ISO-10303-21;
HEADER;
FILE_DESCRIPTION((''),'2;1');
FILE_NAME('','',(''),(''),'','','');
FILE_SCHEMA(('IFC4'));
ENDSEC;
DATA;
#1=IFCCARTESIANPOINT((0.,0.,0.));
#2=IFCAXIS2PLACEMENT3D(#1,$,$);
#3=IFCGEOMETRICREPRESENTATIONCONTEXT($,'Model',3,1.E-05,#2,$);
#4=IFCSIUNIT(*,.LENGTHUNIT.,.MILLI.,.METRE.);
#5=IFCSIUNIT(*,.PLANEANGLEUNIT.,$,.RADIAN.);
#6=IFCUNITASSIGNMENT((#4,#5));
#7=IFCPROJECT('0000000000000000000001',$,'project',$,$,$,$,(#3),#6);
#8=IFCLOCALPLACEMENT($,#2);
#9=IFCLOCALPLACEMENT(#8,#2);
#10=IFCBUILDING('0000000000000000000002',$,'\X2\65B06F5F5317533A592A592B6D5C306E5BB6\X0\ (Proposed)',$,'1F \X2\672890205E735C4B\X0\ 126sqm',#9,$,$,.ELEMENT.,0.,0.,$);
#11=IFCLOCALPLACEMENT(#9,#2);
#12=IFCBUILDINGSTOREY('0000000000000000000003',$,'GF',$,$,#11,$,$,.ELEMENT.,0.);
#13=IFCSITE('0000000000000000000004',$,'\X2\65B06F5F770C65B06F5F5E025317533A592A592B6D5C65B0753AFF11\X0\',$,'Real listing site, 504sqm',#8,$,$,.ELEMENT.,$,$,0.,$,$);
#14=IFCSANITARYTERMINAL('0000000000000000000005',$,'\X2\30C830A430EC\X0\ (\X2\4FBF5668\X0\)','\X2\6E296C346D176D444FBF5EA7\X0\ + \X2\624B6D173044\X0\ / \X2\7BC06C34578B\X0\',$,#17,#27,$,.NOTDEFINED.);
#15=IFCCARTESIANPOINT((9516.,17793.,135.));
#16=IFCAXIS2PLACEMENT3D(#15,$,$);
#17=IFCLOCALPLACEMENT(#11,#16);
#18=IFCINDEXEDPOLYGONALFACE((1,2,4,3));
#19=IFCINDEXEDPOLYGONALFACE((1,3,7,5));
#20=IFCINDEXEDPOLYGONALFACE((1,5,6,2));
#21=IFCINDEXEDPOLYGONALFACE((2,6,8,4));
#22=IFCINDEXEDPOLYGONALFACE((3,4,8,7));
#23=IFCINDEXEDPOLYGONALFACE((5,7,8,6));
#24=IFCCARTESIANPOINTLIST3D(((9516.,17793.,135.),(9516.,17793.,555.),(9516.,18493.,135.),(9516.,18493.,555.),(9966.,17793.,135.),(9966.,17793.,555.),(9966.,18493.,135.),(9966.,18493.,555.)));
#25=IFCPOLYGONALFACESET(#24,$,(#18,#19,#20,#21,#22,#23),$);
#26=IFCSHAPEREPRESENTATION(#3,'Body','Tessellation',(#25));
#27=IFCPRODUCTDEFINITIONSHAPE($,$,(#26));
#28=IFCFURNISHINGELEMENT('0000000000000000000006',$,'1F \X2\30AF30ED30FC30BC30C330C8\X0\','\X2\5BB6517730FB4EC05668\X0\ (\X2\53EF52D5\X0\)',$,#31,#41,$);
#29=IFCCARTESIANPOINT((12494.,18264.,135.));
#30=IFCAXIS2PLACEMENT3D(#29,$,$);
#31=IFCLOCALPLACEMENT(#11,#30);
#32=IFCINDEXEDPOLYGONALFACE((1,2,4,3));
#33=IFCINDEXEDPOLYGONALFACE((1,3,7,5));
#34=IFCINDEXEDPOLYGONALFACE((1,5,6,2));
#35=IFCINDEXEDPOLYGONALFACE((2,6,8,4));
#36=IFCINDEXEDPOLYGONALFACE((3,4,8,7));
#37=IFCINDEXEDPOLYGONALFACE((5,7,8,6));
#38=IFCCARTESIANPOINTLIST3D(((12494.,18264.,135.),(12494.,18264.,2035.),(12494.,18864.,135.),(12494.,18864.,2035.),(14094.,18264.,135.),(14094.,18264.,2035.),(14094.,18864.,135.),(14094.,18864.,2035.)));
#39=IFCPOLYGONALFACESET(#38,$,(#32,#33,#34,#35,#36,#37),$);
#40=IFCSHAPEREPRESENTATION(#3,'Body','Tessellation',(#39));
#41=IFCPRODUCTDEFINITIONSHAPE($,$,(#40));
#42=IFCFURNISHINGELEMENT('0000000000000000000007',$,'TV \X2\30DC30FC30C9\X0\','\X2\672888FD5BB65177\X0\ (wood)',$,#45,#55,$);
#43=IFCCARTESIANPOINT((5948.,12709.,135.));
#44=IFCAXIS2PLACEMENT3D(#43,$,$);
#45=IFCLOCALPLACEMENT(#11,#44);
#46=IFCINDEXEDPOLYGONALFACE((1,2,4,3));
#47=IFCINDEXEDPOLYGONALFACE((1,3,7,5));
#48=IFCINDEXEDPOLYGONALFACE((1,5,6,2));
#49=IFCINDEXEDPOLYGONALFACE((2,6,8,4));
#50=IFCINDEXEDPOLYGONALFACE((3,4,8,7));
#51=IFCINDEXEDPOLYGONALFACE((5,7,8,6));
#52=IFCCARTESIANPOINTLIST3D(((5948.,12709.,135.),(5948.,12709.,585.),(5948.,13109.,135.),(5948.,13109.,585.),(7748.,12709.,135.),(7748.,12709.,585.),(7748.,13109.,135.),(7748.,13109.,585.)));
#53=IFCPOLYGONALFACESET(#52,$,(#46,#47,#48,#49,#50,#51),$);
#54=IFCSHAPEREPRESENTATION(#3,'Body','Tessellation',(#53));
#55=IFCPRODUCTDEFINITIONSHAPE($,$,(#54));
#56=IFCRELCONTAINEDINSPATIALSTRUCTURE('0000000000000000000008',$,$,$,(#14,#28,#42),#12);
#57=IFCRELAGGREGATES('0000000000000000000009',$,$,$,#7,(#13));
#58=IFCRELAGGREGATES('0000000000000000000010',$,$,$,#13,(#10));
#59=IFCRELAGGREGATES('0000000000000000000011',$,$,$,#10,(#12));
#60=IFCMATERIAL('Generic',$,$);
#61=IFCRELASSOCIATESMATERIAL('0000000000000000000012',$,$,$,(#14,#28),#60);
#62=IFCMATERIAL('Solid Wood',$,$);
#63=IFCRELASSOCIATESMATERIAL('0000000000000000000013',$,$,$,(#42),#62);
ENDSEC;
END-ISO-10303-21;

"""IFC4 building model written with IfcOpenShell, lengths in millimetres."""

from ifc_helpers import new_model, si_unit, frame, frame_2d, origin, place, context, project, spatial, rectangle, extrude, material, element, save


model = new_model("IFC4")

# Units and contexts
model_context = context("Model", 3, precision=1e-05, world=origin())
ifc_project = project(units=[si_unit("LENGTHUNIT", "METRE", prefix="MILLI"), si_unit("PLANEANGLEUNIT", "RADIAN")], contexts=[model_context])

# Site, building, storey
site_placement = place(None, origin())
site = spatial("IfcSite", under=ifc_project, at=site_placement, Name="新潟県新潟市北区太夫浜新町１", ObjectType="Real listing site, 504sqm", CompositionType="ELEMENT", RefElevation=0.0)
building_placement = place(site_placement, origin())
building = spatial("IfcBuilding", under=site, at=building_placement, Name="新潟北区太夫浜の家 (Proposed)", ObjectType="1F 木造平屋 126sqm", CompositionType="ELEMENT", ElevationOfRefHeight=0.0, ElevationOfTerrain=0.0)
storey_placement = place(building_placement, origin())
storey = spatial("IfcBuildingStorey", under=building, at=storey_placement, Name="GF", CompositionType="ELEMENT", Elevation=0.0)

# Shared definitions
ifc_material_1 = material(Name="Solid Wood")

# Sanitary terminal
ifc_material_2 = material(Name="Generic")
sanitary_terminal_1_placement = place(storey_placement, frame((9516.0, 17793.0, 135.0)))
element("IfcSanitaryTerminal", 1, at=sanitary_terminal_1_placement, inside=storey, material=ifc_material_2, Name="トイレ (便器)", Description="温水洗浄便座 + 手洗い / 節水型", PredefinedType="NOTDEFINED", context=model_context, shape_type="SweptSolid", body=[
    extrude(rectangle(XDim=450.0, YDim=700.0, at=frame_2d((225.0, 350.0))), frame((9516.0, 17793.0, 135.0)), (0.0, 0.0, 1.0), 420.0),
])

# Furnishing elements
furnishing_1_placement = place(storey_placement, frame((12494.0, 18264.0, 135.0)))
element("IfcFurnishingElement", 2, at=furnishing_1_placement, inside=storey, material=ifc_material_2, Name="1F クローゼット", Description="家具・什器 (可動)", context=model_context, shape_type="SweptSolid", body=[
    extrude(rectangle(XDim=1600.0, YDim=600.0, at=frame_2d((800.0, 300.0))), frame((12494.0, 18264.0, 135.0)), (0.0, 0.0, 1.0), 1900.0),
])
furnishing_2_placement = place(storey_placement, frame((5948.0, 12709.0, 135.0)))
element("IfcFurnishingElement", 3, at=furnishing_2_placement, inside=storey, material=ifc_material_1, Name="TV ボード", Description="木製家具 (wood)", context=model_context, shape_type="SweptSolid", body=[
    extrude(rectangle(XDim=1800.0, YDim=400.0, at=frame_2d((900.0, 200.0))), frame((5948.0, 12709.0, 135.0)), (0.0, 0.0, 1.0), 450.0),
])

save(model, "model.ifc")
